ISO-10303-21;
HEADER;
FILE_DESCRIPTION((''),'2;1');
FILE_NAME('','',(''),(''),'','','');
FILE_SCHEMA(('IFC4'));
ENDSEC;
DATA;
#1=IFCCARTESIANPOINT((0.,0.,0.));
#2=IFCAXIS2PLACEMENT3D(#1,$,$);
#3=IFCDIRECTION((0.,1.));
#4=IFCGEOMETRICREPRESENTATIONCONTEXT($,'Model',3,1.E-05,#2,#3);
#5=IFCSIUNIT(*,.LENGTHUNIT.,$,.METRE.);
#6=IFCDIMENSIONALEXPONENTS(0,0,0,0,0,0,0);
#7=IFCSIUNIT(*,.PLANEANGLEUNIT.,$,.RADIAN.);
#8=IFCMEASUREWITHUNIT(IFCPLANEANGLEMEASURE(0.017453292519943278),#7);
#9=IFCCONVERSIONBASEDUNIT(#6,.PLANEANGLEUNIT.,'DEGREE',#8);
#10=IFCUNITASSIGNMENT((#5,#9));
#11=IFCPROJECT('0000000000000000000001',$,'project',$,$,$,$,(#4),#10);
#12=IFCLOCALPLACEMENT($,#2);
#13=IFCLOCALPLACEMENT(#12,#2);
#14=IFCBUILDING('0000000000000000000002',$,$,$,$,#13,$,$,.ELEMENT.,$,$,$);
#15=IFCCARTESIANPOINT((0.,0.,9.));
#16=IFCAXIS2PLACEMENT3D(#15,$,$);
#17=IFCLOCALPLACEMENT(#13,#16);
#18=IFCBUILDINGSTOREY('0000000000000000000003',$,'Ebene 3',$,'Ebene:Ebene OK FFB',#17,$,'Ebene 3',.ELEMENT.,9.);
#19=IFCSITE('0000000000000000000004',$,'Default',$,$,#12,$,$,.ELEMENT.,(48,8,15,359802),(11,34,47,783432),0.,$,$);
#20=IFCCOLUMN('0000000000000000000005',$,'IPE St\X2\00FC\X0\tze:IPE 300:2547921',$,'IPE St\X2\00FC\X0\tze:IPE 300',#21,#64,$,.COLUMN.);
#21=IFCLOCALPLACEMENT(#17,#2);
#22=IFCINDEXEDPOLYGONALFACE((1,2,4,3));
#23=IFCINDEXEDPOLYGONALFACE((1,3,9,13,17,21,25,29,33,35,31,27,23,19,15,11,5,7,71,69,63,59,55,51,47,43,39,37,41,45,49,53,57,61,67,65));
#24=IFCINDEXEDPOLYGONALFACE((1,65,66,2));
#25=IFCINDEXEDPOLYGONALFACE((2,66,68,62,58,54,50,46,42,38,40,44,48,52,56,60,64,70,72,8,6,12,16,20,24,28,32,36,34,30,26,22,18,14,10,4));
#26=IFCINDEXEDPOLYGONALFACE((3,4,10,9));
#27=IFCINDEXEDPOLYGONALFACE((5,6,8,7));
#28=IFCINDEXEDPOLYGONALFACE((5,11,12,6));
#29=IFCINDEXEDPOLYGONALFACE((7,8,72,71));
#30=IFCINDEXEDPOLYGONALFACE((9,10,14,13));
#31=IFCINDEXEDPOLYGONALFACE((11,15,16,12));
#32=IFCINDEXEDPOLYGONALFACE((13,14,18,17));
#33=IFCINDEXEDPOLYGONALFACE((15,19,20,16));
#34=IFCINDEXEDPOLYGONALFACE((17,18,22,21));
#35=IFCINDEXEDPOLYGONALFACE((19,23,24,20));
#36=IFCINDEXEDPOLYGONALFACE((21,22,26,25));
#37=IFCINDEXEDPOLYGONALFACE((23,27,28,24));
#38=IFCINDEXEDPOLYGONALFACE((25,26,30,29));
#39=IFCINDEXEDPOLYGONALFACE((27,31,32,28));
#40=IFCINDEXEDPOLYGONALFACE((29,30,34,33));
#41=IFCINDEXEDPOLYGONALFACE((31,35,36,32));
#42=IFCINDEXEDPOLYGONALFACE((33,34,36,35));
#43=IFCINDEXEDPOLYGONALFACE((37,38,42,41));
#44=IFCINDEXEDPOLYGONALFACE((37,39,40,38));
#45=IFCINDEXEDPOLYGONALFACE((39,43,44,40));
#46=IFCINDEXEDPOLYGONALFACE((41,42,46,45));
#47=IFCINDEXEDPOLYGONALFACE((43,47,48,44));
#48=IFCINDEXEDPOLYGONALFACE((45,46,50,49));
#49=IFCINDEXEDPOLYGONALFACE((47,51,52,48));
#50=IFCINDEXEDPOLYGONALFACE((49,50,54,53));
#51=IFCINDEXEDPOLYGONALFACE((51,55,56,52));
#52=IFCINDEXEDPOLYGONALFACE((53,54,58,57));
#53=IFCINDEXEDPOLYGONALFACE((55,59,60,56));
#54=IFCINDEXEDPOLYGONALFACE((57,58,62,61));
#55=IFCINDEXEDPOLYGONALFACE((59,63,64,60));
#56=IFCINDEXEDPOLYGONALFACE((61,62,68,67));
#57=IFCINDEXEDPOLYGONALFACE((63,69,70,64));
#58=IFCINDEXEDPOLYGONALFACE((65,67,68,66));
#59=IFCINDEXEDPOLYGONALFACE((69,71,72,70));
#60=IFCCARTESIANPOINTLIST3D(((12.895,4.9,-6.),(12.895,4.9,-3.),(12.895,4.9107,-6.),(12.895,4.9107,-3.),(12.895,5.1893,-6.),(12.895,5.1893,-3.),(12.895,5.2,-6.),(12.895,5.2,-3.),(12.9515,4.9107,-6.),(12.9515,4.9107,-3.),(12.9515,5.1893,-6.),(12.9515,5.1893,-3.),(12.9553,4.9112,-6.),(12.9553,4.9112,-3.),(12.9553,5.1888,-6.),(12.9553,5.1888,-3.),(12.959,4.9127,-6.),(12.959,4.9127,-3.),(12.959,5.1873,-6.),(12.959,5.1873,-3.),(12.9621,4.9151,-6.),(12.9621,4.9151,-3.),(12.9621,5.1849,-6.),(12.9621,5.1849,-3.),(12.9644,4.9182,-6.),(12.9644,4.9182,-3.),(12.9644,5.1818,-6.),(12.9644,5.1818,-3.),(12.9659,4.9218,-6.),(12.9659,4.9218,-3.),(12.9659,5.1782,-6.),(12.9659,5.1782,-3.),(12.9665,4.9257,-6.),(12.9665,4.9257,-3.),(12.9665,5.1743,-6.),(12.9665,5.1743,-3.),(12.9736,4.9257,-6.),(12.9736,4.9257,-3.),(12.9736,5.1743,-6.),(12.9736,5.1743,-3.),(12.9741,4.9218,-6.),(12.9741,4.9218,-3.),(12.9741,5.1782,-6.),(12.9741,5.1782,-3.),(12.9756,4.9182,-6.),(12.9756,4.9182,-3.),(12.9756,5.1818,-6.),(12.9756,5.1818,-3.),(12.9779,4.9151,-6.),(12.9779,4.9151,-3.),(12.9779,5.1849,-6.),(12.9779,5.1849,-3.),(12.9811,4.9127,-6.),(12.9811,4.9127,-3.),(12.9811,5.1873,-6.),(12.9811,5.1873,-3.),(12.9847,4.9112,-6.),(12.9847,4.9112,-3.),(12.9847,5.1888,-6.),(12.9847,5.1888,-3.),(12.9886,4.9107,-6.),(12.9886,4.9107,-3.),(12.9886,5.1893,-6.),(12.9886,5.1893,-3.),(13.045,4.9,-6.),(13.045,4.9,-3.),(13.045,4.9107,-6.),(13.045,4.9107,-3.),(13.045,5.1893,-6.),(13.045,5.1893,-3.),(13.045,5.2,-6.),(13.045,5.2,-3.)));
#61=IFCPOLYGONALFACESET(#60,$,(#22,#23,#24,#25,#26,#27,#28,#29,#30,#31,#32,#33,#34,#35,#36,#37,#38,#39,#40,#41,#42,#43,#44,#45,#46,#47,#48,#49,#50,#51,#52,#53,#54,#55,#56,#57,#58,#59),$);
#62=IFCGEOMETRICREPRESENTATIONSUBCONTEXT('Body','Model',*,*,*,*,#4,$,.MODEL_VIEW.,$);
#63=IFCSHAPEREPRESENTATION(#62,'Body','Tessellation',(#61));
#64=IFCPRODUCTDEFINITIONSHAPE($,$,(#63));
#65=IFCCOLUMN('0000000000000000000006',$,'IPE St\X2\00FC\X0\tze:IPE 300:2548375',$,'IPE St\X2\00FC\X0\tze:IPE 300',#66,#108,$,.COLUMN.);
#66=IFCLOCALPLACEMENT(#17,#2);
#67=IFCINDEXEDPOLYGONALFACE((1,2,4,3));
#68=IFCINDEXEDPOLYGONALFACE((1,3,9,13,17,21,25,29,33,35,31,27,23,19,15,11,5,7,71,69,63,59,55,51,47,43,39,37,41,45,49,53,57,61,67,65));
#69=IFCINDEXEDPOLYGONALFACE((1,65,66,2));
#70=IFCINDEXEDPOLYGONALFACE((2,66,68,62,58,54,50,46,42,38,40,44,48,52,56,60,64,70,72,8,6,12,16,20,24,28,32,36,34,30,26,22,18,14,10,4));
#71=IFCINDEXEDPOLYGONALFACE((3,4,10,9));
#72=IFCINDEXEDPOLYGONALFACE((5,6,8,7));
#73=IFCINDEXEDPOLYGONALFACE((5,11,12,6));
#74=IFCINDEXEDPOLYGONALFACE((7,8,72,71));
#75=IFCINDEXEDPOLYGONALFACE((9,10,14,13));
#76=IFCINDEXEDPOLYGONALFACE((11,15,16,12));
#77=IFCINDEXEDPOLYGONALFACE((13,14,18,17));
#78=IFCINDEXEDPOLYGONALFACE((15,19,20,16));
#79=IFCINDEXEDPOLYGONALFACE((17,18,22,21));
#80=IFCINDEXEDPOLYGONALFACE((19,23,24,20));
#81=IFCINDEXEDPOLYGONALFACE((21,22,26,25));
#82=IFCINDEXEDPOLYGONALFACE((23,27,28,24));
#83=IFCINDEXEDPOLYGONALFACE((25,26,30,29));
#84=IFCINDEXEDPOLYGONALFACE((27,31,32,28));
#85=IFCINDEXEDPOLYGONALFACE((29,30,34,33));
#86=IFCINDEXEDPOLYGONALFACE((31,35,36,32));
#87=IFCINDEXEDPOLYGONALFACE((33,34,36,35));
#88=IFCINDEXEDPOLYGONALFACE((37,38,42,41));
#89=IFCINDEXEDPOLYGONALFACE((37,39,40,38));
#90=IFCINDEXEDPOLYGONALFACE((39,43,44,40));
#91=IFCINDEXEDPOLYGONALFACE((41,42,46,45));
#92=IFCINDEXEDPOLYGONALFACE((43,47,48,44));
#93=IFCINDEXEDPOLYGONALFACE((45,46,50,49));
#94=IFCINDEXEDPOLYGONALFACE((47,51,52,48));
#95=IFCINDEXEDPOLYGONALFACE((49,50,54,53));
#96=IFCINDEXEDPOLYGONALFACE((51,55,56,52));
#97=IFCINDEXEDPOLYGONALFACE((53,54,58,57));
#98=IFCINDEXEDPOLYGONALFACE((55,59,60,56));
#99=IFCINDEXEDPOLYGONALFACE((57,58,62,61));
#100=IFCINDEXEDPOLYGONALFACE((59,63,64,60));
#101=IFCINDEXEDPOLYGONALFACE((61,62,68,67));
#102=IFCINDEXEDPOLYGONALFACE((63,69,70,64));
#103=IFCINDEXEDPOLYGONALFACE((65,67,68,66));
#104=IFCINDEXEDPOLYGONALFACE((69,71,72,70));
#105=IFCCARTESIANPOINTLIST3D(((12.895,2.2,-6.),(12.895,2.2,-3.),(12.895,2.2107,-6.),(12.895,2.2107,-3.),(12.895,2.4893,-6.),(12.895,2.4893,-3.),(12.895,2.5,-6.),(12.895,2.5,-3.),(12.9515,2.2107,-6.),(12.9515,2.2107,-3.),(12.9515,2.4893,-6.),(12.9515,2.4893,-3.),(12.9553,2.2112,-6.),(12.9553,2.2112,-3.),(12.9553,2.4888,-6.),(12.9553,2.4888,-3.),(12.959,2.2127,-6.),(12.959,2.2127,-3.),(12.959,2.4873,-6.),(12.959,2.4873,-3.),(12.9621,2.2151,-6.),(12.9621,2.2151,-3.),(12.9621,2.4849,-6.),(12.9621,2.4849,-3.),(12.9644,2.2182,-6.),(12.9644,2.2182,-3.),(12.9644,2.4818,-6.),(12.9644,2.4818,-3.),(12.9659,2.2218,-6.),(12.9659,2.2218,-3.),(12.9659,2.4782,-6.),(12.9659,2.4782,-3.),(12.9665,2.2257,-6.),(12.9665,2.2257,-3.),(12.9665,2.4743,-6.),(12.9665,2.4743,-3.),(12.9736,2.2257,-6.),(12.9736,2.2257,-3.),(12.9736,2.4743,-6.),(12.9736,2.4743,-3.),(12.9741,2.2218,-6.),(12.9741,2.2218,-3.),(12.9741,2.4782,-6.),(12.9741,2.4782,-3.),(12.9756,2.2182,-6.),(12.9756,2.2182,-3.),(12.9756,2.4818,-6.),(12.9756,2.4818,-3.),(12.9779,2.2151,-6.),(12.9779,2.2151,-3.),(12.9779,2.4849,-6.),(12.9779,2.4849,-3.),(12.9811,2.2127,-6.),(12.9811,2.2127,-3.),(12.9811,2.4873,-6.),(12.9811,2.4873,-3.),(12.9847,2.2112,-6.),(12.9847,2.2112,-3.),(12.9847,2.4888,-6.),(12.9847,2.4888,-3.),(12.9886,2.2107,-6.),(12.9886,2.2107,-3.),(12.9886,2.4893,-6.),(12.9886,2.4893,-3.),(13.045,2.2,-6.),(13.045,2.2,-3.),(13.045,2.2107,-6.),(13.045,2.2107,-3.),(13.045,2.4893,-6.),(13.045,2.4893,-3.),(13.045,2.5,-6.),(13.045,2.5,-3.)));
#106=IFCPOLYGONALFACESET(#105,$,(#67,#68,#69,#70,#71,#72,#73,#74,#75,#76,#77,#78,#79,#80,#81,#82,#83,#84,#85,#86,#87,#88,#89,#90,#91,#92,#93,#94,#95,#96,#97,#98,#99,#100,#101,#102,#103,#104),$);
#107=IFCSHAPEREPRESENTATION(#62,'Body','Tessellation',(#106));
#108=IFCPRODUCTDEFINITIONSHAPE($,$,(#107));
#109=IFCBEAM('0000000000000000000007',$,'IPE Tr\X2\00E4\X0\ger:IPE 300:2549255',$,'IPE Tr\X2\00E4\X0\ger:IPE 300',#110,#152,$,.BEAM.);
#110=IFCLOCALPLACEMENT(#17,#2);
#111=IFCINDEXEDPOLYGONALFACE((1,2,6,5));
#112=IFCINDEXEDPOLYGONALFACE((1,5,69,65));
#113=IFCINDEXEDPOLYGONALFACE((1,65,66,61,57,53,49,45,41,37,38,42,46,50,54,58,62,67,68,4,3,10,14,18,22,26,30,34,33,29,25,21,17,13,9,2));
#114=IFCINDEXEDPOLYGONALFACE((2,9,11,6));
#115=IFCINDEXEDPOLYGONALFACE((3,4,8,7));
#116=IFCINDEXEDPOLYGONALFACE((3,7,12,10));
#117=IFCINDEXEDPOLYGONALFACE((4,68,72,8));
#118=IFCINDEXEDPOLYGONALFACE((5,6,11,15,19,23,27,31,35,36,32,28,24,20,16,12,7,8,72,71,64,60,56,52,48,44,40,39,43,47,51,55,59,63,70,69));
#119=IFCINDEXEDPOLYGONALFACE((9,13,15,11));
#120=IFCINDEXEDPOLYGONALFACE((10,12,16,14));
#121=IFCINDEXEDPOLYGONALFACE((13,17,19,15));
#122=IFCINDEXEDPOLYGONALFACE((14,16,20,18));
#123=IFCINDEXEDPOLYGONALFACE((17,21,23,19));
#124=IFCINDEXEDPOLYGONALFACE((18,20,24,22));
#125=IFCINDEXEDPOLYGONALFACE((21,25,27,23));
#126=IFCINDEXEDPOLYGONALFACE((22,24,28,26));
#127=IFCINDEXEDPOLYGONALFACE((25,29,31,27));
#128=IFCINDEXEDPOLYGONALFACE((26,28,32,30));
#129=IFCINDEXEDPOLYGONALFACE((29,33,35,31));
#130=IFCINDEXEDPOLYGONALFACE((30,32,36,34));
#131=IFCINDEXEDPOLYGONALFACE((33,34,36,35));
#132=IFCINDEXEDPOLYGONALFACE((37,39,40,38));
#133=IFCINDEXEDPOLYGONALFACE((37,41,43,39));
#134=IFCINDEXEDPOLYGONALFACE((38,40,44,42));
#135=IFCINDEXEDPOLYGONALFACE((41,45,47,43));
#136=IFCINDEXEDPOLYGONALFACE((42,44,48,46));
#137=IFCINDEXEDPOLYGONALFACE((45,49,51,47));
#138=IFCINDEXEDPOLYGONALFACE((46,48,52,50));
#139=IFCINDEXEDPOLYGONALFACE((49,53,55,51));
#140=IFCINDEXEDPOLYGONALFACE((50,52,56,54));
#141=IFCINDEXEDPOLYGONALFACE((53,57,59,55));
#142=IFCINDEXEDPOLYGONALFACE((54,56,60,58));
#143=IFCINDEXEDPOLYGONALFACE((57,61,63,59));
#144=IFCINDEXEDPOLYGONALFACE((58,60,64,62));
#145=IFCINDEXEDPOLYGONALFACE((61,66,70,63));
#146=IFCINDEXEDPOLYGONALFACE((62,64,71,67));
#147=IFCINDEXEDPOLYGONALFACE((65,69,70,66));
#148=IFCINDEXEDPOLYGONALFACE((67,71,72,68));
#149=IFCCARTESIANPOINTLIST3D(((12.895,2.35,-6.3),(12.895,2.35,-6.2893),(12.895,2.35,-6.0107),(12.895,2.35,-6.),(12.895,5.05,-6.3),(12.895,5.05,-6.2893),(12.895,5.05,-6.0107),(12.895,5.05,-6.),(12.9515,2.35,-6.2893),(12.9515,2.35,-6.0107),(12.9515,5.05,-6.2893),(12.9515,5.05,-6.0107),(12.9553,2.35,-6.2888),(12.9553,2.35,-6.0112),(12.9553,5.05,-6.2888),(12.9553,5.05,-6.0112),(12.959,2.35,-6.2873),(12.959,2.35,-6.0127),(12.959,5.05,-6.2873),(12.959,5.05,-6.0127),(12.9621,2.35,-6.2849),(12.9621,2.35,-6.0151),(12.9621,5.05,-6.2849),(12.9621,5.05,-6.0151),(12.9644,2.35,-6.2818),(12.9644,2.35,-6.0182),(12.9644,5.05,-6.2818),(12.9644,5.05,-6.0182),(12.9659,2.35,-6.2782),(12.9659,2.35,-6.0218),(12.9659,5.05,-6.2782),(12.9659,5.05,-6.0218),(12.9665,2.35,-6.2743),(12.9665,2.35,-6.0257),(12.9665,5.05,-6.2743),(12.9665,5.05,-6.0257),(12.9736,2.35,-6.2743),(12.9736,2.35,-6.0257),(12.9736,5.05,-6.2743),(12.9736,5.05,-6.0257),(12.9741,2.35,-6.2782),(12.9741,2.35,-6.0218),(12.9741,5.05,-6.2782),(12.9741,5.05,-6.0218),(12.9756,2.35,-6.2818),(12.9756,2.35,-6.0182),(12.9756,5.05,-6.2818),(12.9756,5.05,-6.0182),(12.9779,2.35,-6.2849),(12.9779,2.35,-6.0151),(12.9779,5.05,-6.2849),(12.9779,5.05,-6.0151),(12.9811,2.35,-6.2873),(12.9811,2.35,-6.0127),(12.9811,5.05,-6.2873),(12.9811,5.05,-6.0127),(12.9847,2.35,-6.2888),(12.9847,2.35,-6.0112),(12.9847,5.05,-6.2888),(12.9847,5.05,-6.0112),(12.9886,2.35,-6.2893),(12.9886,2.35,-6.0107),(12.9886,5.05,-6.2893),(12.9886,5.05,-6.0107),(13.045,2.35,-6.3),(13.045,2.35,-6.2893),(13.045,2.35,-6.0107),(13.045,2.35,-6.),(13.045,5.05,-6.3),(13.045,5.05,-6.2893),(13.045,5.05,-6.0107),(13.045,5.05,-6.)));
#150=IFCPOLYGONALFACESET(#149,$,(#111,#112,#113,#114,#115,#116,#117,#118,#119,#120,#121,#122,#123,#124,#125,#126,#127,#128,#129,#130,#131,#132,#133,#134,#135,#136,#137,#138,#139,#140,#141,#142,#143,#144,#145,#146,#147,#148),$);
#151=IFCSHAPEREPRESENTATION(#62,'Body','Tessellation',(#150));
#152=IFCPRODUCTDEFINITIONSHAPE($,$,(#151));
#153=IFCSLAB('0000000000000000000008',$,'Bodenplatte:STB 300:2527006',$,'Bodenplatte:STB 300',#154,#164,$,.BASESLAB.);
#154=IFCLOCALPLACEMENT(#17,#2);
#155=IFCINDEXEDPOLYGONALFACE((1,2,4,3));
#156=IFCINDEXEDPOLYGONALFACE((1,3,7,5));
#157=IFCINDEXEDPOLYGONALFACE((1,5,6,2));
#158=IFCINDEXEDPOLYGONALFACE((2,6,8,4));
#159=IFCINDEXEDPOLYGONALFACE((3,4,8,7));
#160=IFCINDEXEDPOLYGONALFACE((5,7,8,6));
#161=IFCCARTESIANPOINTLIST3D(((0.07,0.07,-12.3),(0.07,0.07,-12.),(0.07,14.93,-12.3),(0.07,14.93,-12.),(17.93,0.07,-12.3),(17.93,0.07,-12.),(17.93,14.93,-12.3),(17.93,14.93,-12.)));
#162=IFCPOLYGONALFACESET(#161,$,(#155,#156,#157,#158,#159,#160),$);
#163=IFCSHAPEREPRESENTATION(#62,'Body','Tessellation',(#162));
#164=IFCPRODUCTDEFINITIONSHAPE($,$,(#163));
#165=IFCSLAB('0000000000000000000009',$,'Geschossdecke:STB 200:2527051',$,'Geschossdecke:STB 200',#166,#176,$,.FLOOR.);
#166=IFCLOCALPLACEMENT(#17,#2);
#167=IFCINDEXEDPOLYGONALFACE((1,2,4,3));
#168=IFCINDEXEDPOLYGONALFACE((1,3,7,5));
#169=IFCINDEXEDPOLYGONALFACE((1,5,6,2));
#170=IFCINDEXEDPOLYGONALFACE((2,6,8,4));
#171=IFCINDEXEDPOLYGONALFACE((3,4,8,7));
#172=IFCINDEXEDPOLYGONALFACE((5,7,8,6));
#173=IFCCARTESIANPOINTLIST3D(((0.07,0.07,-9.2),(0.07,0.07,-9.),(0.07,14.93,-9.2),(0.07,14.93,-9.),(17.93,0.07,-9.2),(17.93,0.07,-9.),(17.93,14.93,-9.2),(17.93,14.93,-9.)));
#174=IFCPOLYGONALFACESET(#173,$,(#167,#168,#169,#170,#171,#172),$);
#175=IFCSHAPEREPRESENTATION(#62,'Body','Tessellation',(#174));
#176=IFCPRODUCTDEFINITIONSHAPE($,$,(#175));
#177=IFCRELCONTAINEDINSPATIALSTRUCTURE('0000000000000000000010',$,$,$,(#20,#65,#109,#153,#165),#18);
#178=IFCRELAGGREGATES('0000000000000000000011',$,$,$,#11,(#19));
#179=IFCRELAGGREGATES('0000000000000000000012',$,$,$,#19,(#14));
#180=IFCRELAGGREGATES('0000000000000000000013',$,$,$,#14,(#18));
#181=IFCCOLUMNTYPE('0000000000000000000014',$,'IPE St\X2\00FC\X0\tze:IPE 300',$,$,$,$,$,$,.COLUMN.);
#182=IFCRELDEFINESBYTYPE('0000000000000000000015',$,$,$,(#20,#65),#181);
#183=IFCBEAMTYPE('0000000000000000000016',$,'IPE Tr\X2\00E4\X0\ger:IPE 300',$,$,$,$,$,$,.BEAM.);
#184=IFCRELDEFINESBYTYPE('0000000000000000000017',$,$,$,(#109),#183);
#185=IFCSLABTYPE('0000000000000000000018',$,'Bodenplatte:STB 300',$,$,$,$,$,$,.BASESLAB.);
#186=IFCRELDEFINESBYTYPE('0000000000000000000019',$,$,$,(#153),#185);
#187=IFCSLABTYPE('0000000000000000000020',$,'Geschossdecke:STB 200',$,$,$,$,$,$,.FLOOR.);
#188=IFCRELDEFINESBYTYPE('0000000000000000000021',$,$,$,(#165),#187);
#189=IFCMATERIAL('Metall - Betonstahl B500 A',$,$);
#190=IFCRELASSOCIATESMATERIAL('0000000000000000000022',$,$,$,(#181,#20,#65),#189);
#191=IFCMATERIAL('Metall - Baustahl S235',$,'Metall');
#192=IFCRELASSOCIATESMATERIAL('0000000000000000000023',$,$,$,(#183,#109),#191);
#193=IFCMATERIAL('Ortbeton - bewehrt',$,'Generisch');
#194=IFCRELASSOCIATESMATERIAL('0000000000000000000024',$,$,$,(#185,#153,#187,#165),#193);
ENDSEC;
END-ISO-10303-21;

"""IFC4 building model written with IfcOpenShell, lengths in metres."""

from ifc_helpers import new_model, entity, si_unit, converted_unit, direction, frame, origin, place, context, subcontext, project, spatial, line, arc, indexed_curve, outline, extrude, source, transform, mapped, material, type_object, type_shapes, element, save


model = new_model("IFC4")

# Units and contexts
model_context = context("Model", 3, precision=1e-05, world=origin(), true_north=direction((0.0, 1.0)))
body_context = subcontext(model_context, "Body", "Model", "MODEL_VIEW")
ifc_project = project(units=[si_unit("LENGTHUNIT", "METRE"), converted_unit("PLANEANGLEUNIT", "DEGREE", entity("IfcPlaneAngleMeasure", 0.017453292519943278), si_unit("PLANEANGLEUNIT", "RADIAN"), dimensions=[0, 0, 0, 0, 0, 0, 0])], contexts=[model_context])

# Site, building, storey
site_placement = place(None, origin())
site = spatial("IfcSite", under=ifc_project, at=site_placement, Name="Default", CompositionType="ELEMENT", RefLatitude=(48, 8, 15, 359802), RefLongitude=(11, 34, 47, 783432), RefElevation=0.0)
building_placement = place(site_placement, origin())
building = spatial("IfcBuilding", under=site, at=building_placement, CompositionType="ELEMENT")
storey_placement = place(building_placement, frame((0.0, 0.0, 9.0)))
storey = spatial("IfcBuildingStorey", under=building, at=storey_placement, Name="Ebene 3", ObjectType="Ebene:Ebene OK FFB", LongName="Ebene 3", CompositionType="ELEMENT", Elevation=9.0)

# Columns
ifc_material_1 = material(Name="Metall - Betonstahl B500 A")
column_type_1 = type_object("IfcColumnType", Name="IPE Stütze:IPE 300", PredefinedType="COLUMN", material=ifc_material_1)
shared_shape_1 = source(origin(), body_context, "Body", "SweptSolid", [
    extrude(outline(indexed_curve([(-0.075, -0.15), (0.075, -0.15), (0.075, -0.1393), (0.0186, -0.1393), (0.0079, -0.1349), (0.0035, -0.1243), (0.0035, 0.1243), (0.0079, 0.1349), (0.0185, 0.1393), (0.075, 0.1393), (0.075, 0.15), (-0.075, 0.15), (-0.075, 0.1393), (-0.0186, 0.1393), (-0.0079, 0.1349), (-0.0035, 0.1243), (-0.0036, -0.1243), (-0.0079, -0.1349), (-0.0186, -0.1393), (-0.075, -0.1393)], segments=[line(1, 2, 3, 4), arc(4, 5, 6), line(6, 7), arc(7, 8, 9), line(9, 10, 11, 12, 13, 14), arc(14, 15, 16), line(16, 17), arc(17, 18, 19), line(19, 20, 1)], self_intersect=False)), frame((0.0, 0.0, 3.0), z_axis=(0.0, 0.0, 1.0), x_axis=(-1.0, 0.0, 0.0)), (0.0, 0.0, 1.0), 3.0),
])
type_shapes(column_type_1, [shared_shape_1])
for number, where, name in (
    (1, (12.97, 5.05, -9.0), "IPE Stütze:IPE 300:2547921"),
    (2, (12.97, 2.35, -9.0), "IPE Stütze:IPE 300:2548375"),
):
    element("IfcColumn", number, at=place(storey_placement, frame(where)), inside=storey, type_object=column_type_1, material=ifc_material_1, Name=name, ObjectType="IPE Stütze:IPE 300", PredefinedType="COLUMN", context=body_context, shape_type="MappedRepresentation", body=[
        mapped(shared_shape_1, transform((0.0, 0.0, 0.0), scale=1.0)),
    ])

# Beam
ifc_material_2 = material(Name="Metall - Baustahl S235", Category="Metall")
beam_type = type_object("IfcBeamType", Name="IPE Träger:IPE 300", PredefinedType="BEAM", material=ifc_material_2)
shared_shape_2 = source(origin(), body_context, "Body", "SweptSolid", [
    extrude(outline(indexed_curve([(-0.075, -0.15), (0.075, -0.15), (0.075, -0.1393), (0.0186, -0.1393), (0.0079, -0.1349), (0.0036, -0.1243), (0.0036, 0.1243), (0.0079, 0.1349), (0.0186, 0.1393), (0.075, 0.1393), (0.075, 0.15), (-0.075, 0.15), (-0.075, 0.1393), (-0.0185, 0.1393), (-0.0079, 0.1349), (-0.0035, 0.1243), (-0.0035, -0.1243), (-0.0079, -0.1349), (-0.0185, -0.1393), (-0.075, -0.1393)], segments=[line(1, 2, 3, 4), arc(4, 5, 6), line(6, 7), arc(7, 8, 9), line(9, 10, 11, 12, 13, 14), arc(14, 15, 16), line(16, 17), arc(17, 18, 19), line(19, 20, 1)], self_intersect=False)), frame((12.97, 5.05, 2.85), z_axis=(0.0, -1.0, 0.0), x_axis=(-1.0, 0.0, 0.0)), (0.0, 0.0, 1.0), 2.7),
])
type_shapes(beam_type, [shared_shape_2])
beam_placement = place(storey_placement, frame((0.0, 0.0, -9.0)))
element("IfcBeam", 3, at=beam_placement, inside=storey, type_object=beam_type, material=ifc_material_2, Name="IPE Träger:IPE 300:2549255", ObjectType="IPE Träger:IPE 300", PredefinedType="BEAM", context=body_context, shape_type="MappedRepresentation", body=[
    mapped(shared_shape_2, transform((0.0, 0.0, 0.0), scale=1.0)),
])

# Slabs
ifc_material_3 = material(Name="Ortbeton - bewehrt", Category="Generisch")
slab_type_1 = type_object("IfcSlabType", Name="Bodenplatte:STB 300", PredefinedType="BASESLAB", material=ifc_material_3)
slab_1_placement = place(storey_placement, origin())
element("IfcSlab", 4, at=slab_1_placement, inside=storey, type_object=slab_type_1, material=ifc_material_3, Name="Bodenplatte:STB 300:2527006", ObjectType="Bodenplatte:STB 300", PredefinedType="BASESLAB", context=body_context, shape_type="SweptSolid", body=[
    extrude(outline(indexed_curve([(-7.43, -8.93), (7.43, -8.93), (7.43, 8.93), (-7.43, 8.93), (-7.43, -8.93)], self_intersect=False)), frame((9.0, 7.5, -12.0), z_axis=(0.0, 0.0, -1.0), x_axis=(0.0, 1.0, 0.0)), (0.0, 0.0, 1.0), 0.3),
])
slab_type_2 = type_object("IfcSlabType", Name="Geschossdecke:STB 200", PredefinedType="FLOOR", material=ifc_material_3)
slab_2_placement = place(storey_placement, origin())
element("IfcSlab", 5, at=slab_2_placement, inside=storey, type_object=slab_type_2, material=ifc_material_3, Name="Geschossdecke:STB 200:2527051", ObjectType="Geschossdecke:STB 200", PredefinedType="FLOOR", context=body_context, shape_type="SweptSolid", body=[
    extrude(outline(indexed_curve([(-7.43, -8.93), (7.43, -8.93), (7.43, 8.93), (-7.43, 8.93), (-7.43, -8.93)], self_intersect=False)), frame((9.0, 7.5, -9.0), z_axis=(0.0, 0.0, -1.0), x_axis=(0.0, 1.0, 0.0)), (0.0, 0.0, 1.0), 0.2),
])

save(model, "model.ifc")
